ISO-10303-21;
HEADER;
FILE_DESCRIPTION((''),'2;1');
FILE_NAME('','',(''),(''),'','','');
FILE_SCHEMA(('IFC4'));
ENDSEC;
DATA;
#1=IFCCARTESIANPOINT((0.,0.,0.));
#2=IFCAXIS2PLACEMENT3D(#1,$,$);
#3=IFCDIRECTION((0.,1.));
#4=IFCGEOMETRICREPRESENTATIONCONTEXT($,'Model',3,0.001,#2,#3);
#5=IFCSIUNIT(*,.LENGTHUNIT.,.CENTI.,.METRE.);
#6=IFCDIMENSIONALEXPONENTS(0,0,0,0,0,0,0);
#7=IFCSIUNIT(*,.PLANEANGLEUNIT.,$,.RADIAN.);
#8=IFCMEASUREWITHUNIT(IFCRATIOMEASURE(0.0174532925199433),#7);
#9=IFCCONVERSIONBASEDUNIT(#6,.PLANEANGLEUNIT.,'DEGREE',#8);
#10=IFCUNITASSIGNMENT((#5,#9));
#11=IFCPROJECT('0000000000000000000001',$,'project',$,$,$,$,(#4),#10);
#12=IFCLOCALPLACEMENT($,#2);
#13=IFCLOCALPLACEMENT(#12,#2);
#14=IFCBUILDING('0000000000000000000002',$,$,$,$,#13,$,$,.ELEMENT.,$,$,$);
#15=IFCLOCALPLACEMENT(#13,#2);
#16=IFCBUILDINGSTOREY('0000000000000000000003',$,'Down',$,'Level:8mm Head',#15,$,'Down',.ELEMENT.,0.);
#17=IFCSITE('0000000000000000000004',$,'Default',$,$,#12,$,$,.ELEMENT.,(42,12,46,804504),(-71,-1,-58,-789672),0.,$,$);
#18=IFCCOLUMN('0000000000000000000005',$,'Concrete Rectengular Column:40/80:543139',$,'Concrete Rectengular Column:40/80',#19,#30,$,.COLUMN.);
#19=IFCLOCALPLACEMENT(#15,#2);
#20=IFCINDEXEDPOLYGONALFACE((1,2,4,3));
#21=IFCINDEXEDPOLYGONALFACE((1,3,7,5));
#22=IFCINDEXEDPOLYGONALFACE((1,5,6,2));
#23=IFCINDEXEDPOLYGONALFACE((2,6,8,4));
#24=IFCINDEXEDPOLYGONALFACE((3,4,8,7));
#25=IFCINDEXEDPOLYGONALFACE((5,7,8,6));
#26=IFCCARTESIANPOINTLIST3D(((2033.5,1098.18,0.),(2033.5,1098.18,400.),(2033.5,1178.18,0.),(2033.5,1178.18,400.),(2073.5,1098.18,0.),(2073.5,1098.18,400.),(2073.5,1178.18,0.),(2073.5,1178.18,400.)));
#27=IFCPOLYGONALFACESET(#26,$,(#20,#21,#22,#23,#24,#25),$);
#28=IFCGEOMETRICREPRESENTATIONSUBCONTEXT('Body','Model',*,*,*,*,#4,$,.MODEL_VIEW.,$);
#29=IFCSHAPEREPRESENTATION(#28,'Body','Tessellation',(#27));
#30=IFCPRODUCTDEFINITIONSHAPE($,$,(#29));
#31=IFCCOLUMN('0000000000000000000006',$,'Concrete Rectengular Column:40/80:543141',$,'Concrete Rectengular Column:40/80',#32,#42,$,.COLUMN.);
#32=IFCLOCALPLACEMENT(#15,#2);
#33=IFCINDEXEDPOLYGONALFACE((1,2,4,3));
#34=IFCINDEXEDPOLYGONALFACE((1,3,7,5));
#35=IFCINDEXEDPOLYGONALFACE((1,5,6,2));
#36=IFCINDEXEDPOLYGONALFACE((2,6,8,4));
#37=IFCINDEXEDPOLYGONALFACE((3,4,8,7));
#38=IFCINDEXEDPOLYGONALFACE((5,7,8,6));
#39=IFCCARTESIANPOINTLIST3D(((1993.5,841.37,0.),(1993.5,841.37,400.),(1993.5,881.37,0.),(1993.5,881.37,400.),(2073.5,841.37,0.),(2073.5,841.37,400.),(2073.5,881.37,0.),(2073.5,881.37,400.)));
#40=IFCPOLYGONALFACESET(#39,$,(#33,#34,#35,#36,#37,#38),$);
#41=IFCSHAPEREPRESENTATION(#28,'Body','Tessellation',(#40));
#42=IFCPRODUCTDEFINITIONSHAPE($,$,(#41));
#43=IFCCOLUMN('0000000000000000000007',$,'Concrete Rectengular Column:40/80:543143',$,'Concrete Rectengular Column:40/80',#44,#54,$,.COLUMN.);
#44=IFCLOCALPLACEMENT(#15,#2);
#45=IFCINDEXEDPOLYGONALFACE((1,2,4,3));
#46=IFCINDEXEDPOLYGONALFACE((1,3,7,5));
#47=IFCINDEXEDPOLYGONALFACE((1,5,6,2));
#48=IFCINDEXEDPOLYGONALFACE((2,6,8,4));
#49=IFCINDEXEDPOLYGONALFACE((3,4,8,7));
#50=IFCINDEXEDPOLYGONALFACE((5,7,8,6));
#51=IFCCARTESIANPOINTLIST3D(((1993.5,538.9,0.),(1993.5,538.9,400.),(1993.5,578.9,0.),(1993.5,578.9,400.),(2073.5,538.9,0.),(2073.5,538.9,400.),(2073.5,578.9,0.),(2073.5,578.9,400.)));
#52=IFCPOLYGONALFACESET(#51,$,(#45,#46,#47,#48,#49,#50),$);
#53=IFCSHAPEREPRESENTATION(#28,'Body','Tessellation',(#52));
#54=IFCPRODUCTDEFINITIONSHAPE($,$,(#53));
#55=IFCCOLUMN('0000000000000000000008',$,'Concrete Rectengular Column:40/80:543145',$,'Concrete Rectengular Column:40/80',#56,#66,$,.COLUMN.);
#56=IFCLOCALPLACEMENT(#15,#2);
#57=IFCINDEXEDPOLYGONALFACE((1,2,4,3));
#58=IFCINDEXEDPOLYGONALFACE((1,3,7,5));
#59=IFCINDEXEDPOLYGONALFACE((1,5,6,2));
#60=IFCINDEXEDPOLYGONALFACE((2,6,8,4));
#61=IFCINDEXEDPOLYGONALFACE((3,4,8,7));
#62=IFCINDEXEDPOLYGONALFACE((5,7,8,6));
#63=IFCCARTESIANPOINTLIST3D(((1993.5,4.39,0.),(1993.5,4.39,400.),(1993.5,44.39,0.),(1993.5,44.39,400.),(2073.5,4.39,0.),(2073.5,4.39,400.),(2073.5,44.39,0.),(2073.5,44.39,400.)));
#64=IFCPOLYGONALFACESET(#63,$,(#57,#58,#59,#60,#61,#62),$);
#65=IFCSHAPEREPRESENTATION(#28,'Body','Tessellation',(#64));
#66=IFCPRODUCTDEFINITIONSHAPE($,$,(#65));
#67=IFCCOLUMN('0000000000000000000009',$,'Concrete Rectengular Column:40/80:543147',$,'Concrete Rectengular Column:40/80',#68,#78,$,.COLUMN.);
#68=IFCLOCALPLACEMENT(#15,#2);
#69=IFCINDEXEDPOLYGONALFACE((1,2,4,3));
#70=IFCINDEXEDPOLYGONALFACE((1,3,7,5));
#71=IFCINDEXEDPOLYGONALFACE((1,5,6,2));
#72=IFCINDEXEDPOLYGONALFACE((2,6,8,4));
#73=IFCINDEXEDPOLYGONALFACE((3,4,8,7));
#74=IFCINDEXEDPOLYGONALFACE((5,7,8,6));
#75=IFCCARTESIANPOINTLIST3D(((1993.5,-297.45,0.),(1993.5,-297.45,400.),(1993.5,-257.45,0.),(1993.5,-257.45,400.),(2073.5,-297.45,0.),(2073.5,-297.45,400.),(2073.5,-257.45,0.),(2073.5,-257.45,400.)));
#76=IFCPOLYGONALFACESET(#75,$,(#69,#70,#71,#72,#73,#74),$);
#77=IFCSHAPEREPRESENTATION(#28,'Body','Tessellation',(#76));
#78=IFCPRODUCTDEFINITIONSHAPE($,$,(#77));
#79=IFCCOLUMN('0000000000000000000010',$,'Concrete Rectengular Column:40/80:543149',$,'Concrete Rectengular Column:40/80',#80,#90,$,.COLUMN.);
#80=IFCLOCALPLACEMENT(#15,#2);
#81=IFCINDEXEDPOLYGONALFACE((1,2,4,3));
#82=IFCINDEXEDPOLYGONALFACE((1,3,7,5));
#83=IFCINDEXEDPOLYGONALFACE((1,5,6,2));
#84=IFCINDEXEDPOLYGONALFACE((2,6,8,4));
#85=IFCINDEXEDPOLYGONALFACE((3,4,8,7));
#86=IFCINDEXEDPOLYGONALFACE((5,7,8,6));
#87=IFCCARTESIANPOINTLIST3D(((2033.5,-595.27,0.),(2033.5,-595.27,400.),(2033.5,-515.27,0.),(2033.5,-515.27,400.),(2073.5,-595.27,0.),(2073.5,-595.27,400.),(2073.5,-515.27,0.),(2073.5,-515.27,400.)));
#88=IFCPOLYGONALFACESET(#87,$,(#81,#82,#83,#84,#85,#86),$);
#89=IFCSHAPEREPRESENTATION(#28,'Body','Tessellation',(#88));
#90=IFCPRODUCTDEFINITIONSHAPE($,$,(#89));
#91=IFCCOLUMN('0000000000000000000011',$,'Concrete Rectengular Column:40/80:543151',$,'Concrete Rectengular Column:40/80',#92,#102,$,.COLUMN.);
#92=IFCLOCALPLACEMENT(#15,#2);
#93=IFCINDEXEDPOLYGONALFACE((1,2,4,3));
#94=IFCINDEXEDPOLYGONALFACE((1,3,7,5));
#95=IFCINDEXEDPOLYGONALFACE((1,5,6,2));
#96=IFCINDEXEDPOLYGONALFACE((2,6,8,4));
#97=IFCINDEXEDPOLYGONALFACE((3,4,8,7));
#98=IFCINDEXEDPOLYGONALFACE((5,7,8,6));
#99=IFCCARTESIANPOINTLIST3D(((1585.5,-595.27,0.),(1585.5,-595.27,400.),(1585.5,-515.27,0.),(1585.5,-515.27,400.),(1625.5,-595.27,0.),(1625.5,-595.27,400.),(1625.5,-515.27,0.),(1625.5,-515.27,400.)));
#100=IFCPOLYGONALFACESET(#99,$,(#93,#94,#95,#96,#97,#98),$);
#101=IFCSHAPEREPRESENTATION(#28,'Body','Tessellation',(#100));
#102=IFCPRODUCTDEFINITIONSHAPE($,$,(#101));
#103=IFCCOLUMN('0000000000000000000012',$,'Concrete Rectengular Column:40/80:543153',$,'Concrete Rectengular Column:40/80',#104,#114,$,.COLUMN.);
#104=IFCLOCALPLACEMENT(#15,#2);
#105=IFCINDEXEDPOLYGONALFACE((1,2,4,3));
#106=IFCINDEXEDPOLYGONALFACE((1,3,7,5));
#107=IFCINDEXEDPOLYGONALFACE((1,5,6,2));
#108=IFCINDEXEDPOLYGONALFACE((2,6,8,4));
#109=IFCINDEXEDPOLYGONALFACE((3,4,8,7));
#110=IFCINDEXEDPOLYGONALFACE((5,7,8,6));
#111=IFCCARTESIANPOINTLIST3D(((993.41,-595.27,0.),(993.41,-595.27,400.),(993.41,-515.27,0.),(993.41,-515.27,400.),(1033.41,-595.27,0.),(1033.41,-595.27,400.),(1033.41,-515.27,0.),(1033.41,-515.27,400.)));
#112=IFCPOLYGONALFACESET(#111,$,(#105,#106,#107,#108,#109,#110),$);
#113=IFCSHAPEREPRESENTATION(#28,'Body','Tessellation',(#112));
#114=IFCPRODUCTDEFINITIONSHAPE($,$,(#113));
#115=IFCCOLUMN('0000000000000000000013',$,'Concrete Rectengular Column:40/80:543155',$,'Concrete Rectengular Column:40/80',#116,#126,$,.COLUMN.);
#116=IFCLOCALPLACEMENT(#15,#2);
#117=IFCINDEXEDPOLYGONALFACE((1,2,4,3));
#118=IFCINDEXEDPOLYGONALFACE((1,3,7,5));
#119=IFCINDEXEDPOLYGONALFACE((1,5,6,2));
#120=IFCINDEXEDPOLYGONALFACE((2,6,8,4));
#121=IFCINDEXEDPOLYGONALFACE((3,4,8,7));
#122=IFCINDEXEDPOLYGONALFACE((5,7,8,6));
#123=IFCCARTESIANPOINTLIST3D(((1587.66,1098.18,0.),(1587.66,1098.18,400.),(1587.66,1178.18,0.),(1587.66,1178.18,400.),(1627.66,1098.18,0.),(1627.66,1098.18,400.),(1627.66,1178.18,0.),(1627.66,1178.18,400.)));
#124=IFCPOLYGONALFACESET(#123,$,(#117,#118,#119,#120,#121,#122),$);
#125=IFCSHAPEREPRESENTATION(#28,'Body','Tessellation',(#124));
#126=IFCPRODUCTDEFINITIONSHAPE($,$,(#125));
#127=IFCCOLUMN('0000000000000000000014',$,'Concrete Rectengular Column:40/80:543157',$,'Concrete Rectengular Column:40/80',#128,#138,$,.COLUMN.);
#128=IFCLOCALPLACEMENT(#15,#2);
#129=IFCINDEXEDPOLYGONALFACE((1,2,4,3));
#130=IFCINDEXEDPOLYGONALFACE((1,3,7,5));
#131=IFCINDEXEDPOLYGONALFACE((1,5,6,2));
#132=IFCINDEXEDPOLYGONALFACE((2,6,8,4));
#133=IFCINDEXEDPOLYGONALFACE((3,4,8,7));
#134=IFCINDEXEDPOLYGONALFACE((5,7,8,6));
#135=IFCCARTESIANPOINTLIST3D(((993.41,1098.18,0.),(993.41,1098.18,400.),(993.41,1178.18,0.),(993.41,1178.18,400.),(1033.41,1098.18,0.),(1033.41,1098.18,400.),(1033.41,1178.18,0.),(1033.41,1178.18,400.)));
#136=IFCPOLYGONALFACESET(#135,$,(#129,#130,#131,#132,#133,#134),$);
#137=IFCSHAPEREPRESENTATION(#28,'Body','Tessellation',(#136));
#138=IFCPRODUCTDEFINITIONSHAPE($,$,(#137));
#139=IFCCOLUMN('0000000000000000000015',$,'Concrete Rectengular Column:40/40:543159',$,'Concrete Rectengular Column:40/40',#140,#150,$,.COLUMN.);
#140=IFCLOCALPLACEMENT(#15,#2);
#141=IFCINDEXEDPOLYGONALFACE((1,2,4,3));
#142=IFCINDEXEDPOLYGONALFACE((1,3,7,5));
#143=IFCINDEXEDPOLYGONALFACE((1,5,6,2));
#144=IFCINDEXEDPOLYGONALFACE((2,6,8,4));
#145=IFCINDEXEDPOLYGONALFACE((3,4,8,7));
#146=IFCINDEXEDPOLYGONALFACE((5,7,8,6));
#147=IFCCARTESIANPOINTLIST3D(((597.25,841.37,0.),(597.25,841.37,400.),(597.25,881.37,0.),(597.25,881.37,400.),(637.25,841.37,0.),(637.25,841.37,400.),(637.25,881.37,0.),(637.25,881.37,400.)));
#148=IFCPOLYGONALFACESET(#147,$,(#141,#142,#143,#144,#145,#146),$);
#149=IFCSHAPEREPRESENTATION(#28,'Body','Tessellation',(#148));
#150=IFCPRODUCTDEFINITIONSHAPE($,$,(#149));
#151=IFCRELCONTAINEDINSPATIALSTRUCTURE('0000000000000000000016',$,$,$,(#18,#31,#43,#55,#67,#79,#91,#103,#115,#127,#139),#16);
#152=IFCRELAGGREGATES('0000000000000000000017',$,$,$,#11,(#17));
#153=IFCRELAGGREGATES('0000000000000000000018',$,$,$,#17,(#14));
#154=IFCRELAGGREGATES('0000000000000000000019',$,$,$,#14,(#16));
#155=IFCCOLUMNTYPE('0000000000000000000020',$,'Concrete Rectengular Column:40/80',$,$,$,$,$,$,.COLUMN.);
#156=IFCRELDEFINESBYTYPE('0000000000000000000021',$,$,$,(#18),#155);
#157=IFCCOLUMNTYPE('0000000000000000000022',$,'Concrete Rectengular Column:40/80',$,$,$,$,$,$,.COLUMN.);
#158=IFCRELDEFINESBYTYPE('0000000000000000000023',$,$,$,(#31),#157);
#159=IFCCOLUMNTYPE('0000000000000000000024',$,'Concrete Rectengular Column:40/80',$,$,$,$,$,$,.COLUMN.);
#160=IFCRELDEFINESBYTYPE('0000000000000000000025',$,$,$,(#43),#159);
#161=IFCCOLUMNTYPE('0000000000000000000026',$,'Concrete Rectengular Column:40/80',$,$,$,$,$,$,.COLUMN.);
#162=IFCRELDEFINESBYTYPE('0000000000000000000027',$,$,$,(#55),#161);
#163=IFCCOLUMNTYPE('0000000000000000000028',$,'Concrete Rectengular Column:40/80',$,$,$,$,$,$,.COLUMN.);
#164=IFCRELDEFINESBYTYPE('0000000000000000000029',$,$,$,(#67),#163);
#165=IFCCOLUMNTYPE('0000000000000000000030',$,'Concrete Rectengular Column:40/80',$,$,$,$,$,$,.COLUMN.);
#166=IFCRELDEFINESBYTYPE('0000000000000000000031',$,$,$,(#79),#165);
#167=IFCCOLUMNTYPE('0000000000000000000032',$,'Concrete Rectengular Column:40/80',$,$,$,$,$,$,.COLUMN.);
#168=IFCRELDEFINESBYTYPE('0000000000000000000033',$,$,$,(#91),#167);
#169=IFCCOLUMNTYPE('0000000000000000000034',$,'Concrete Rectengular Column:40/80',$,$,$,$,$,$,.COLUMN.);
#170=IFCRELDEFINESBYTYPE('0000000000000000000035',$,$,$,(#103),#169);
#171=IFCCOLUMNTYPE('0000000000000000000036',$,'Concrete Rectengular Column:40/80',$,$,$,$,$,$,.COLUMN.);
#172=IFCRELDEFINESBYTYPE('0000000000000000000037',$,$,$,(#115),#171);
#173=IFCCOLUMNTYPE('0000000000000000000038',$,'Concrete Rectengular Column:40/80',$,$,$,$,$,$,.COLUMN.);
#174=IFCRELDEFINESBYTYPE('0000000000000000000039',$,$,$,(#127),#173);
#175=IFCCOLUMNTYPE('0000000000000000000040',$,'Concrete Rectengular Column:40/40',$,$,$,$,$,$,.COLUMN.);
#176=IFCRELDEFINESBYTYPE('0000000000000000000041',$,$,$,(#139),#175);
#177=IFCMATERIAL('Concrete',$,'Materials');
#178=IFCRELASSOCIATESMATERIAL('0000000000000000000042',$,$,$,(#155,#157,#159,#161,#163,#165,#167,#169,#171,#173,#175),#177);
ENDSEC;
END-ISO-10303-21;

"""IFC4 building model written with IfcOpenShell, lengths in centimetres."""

from ifc_helpers import new_model, entity, si_unit, converted_unit, direction, frame, origin, place, context, subcontext, project, spatial, indexed_curve, outline, extrude, source, transform, mapped, material, type_object, type_shapes, element, save


model = new_model("IFC4")

# Units and contexts
model_context = context("Model", 3, precision=0.001, world=origin(), true_north=direction((0.0, 1.0)))
body_context = subcontext(model_context, "Body", "Model", "MODEL_VIEW")
ifc_project = project(units=[si_unit("LENGTHUNIT", "METRE", prefix="CENTI"), converted_unit("PLANEANGLEUNIT", "DEGREE", entity("IfcRatioMeasure", 0.0174532925199433), si_unit("PLANEANGLEUNIT", "RADIAN"), dimensions=[0, 0, 0, 0, 0, 0, 0])], contexts=[model_context])

# Site, building, storey
site_placement = place(None, origin())
site = spatial("IfcSite", under=ifc_project, at=site_placement, Name="Default", CompositionType="ELEMENT", RefLatitude=(42, 12, 46, 804504), RefLongitude=(-71, -1, -58, -789672), RefElevation=0.0)
building_placement = place(site_placement, origin())
building = spatial("IfcBuilding", under=site, at=building_placement, CompositionType="ELEMENT")
storey_placement = place(building_placement, origin())
storey = spatial("IfcBuildingStorey", under=building, at=storey_placement, Name="Down", ObjectType="Level:8mm Head", LongName="Down", CompositionType="ELEMENT", Elevation=0.0)

# Columns
ifc_material = material(Name="Concrete", Category="Materials")
column_type_1 = type_object("IfcColumnType", Name="Concrete Rectengular Column:40/80", PredefinedType="COLUMN", material=ifc_material)
shared_shape_1 = source(origin(), body_context, "Body", "SweptSolid", [
    extrude(outline(indexed_curve([(-40.0, -20.0), (40.0, -20.0), (40.0, 20.0), (-40.0, 20.0), (-40.0, -20.0)], self_intersect=False)), frame((2053.5, 1138.18, 0.0), z_axis=(0.0, 0.0, 1.0), x_axis=(0.0, -1.0, 0.0)), (0.0, 0.0, 1.0), 400.0),
])
type_shapes(column_type_1, [shared_shape_1])
column_1_placement = place(storey_placement, origin())
element("IfcColumn", 1, at=column_1_placement, inside=storey, type_object=column_type_1, Name="Concrete Rectengular Column:40/80:543139", ObjectType="Concrete Rectengular Column:40/80", PredefinedType="COLUMN", context=body_context, shape_type="MappedRepresentation", body=[
    mapped(shared_shape_1, transform((0.0, 0.0, 0.0), scale=1.0)),
])
column_type_2 = type_object("IfcColumnType", Name="Concrete Rectengular Column:40/80", PredefinedType="COLUMN", material=ifc_material)
shared_shape_2 = source(origin(), body_context, "Body", "SweptSolid", [
    extrude(outline(indexed_curve([(-20.0, -40.0), (20.0, -40.0), (20.0, 40.0), (-20.0, 40.0), (-20.0, -40.0)], self_intersect=False)), frame((2033.5, 861.37, 0.0), z_axis=(0.0, 0.0, 1.0), x_axis=(0.0, -1.0, 0.0)), (0.0, 0.0, 1.0), 400.0),
])
type_shapes(column_type_2, [shared_shape_2])
column_2_placement = place(storey_placement, origin())
element("IfcColumn", 2, at=column_2_placement, inside=storey, type_object=column_type_2, Name="Concrete Rectengular Column:40/80:543141", ObjectType="Concrete Rectengular Column:40/80", PredefinedType="COLUMN", context=body_context, shape_type="MappedRepresentation", body=[
    mapped(shared_shape_2, transform((0.0, 0.0, 0.0), scale=1.0)),
])
column_type_3 = type_object("IfcColumnType", Name="Concrete Rectengular Column:40/80", PredefinedType="COLUMN", material=ifc_material)
shared_shape_3 = source(origin(), body_context, "Body", "SweptSolid", [
    extrude(outline(indexed_curve([(-20.0, -40.0), (20.0, -40.0), (20.0, 40.0), (-20.0, 40.0), (-20.0, -40.0)], self_intersect=False)), frame((2033.5, 558.9, 0.0), z_axis=(0.0, 0.0, 1.0), x_axis=(0.0, -1.0, 0.0)), (0.0, 0.0, 1.0), 400.0),
])
type_shapes(column_type_3, [shared_shape_3])
column_3_placement = place(storey_placement, origin())
element("IfcColumn", 3, at=column_3_placement, inside=storey, type_object=column_type_3, Name="Concrete Rectengular Column:40/80:543143", ObjectType="Concrete Rectengular Column:40/80", PredefinedType="COLUMN", context=body_context, shape_type="MappedRepresentation", body=[
    mapped(shared_shape_3, transform((0.0, 0.0, 0.0), scale=1.0)),
])
column_type_4 = type_object("IfcColumnType", Name="Concrete Rectengular Column:40/80", PredefinedType="COLUMN", material=ifc_material)
shared_shape_4 = source(origin(), body_context, "Body", "SweptSolid", [
    extrude(outline(indexed_curve([(-20.0, -40.0), (20.0, -40.0), (20.0, 40.0), (-20.0, 40.0), (-20.0, -40.0)], self_intersect=False)), frame((2033.5, 24.39, 0.0), z_axis=(0.0, 0.0, 1.0), x_axis=(0.0, -1.0, 0.0)), (0.0, 0.0, 1.0), 400.0),
])
type_shapes(column_type_4, [shared_shape_4])
column_4_placement = place(storey_placement, origin())
element("IfcColumn", 4, at=column_4_placement, inside=storey, type_object=column_type_4, Name="Concrete Rectengular Column:40/80:543145", ObjectType="Concrete Rectengular Column:40/80", PredefinedType="COLUMN", context=body_context, shape_type="MappedRepresentation", body=[
    mapped(shared_shape_4, transform((0.0, 0.0, 0.0), scale=1.0)),
])
column_type_5 = type_object("IfcColumnType", Name="Concrete Rectengular Column:40/80", PredefinedType="COLUMN", material=ifc_material)
shared_shape_5 = source(origin(), body_context, "Body", "SweptSolid", [
    extrude(outline(indexed_curve([(-20.0, -40.0), (20.0, -40.0), (20.0, 40.0), (-20.0, 40.0), (-20.0, -40.0)], self_intersect=False)), frame((2033.5, -277.45, 0.0), z_axis=(0.0, 0.0, 1.0), x_axis=(0.0, -1.0, 0.0)), (0.0, 0.0, 1.0), 400.0),
])
type_shapes(column_type_5, [shared_shape_5])
column_5_placement = place(storey_placement, origin())
element("IfcColumn", 5, at=column_5_placement, inside=storey, type_object=column_type_5, Name="Concrete Rectengular Column:40/80:543147", ObjectType="Concrete Rectengular Column:40/80", PredefinedType="COLUMN", context=body_context, shape_type="MappedRepresentation", body=[
    mapped(shared_shape_5, transform((0.0, 0.0, 0.0), scale=1.0)),
])
column_type_6 = type_object("IfcColumnType", Name="Concrete Rectengular Column:40/80", PredefinedType="COLUMN", material=ifc_material)
shared_shape_6 = source(origin(), body_context, "Body", "SweptSolid", [
    extrude(outline(indexed_curve([(-40.0, -20.0), (40.0, -20.0), (40.0, 20.0), (-40.0, 20.0), (-40.0, -20.0)], self_intersect=False)), frame((2053.5, -555.27, 0.0), z_axis=(0.0, 0.0, 1.0), x_axis=(0.0, -1.0, 0.0)), (0.0, 0.0, 1.0), 400.0),
])
type_shapes(column_type_6, [shared_shape_6])
column_6_placement = place(storey_placement, origin())
element("IfcColumn", 6, at=column_6_placement, inside=storey, type_object=column_type_6, Name="Concrete Rectengular Column:40/80:543149", ObjectType="Concrete Rectengular Column:40/80", PredefinedType="COLUMN", context=body_context, shape_type="MappedRepresentation", body=[
    mapped(shared_shape_6, transform((0.0, 0.0, 0.0), scale=1.0)),
])
column_type_7 = type_object("IfcColumnType", Name="Concrete Rectengular Column:40/80", PredefinedType="COLUMN", material=ifc_material)
shared_shape_7 = source(origin(), body_context, "Body", "SweptSolid", [
    extrude(outline(indexed_curve([(-40.0, -20.0), (40.0, -20.0), (40.0, 20.0), (-40.0, 20.0), (-40.0, -20.0)], self_intersect=False)), frame((1605.5, -555.27, 0.0), z_axis=(0.0, 0.0, 1.0), x_axis=(0.0, -1.0, 0.0)), (0.0, 0.0, 1.0), 400.0),
])
type_shapes(column_type_7, [shared_shape_7])
column_7_placement = place(storey_placement, origin())
element("IfcColumn", 7, at=column_7_placement, inside=storey, type_object=column_type_7, Name="Concrete Rectengular Column:40/80:543151", ObjectType="Concrete Rectengular Column:40/80", PredefinedType="COLUMN", context=body_context, shape_type="MappedRepresentation", body=[
    mapped(shared_shape_7, transform((0.0, 0.0, 0.0), scale=1.0)),
])
column_type_8 = type_object("IfcColumnType", Name="Concrete Rectengular Column:40/80", PredefinedType="COLUMN", material=ifc_material)
shared_shape_8 = source(origin(), body_context, "Body", "SweptSolid", [
    extrude(outline(indexed_curve([(-40.0, -20.0), (40.0, -20.0), (40.0, 20.0), (-40.0, 20.0), (-40.0, -20.0)], self_intersect=False)), frame((1013.41, -555.27, 0.0), z_axis=(0.0, 0.0, 1.0), x_axis=(0.0, -1.0, 0.0)), (0.0, 0.0, 1.0), 400.0),
])
type_shapes(column_type_8, [shared_shape_8])
column_8_placement = place(storey_placement, origin())
element("IfcColumn", 8, at=column_8_placement, inside=storey, type_object=column_type_8, Name="Concrete Rectengular Column:40/80:543153", ObjectType="Concrete Rectengular Column:40/80", PredefinedType="COLUMN", context=body_context, shape_type="MappedRepresentation", body=[
    mapped(shared_shape_8, transform((0.0, 0.0, 0.0), scale=1.0)),
])
column_type_9 = type_object("IfcColumnType", Name="Concrete Rectengular Column:40/80", PredefinedType="COLUMN", material=ifc_material)
shared_shape_9 = source(origin(), body_context, "Body", "SweptSolid", [
    extrude(outline(indexed_curve([(-40.0, -20.0), (40.0, -20.0), (40.0, 20.0), (-40.0, 20.0), (-40.0, -20.0)], self_intersect=False)), frame((1607.66, 1138.18, 0.0), z_axis=(0.0, 0.0, 1.0), x_axis=(0.0, -1.0, 0.0)), (0.0, 0.0, 1.0), 400.0),
])
type_shapes(column_type_9, [shared_shape_9])
column_9_placement = place(storey_placement, origin())
element("IfcColumn", 9, at=column_9_placement, inside=storey, type_object=column_type_9, Name="Concrete Rectengular Column:40/80:543155", ObjectType="Concrete Rectengular Column:40/80", PredefinedType="COLUMN", context=body_context, shape_type="MappedRepresentation", body=[
    mapped(shared_shape_9, transform((0.0, 0.0, 0.0), scale=1.0)),
])
column_type_10 = type_object("IfcColumnType", Name="Concrete Rectengular Column:40/80", PredefinedType="COLUMN", material=ifc_material)
shared_shape_10 = source(origin(), body_context, "Body", "SweptSolid", [
    extrude(outline(indexed_curve([(-40.0, -20.0), (40.0, -20.0), (40.0, 20.0), (-40.0, 20.0), (-40.0, -20.0)], self_intersect=False)), frame((1013.41, 1138.18, 0.0), z_axis=(0.0, 0.0, 1.0), x_axis=(0.0, -1.0, 0.0)), (0.0, 0.0, 1.0), 400.0),
])
type_shapes(column_type_10, [shared_shape_10])
column_10_placement = place(storey_placement, origin())
element("IfcColumn", 10, at=column_10_placement, inside=storey, type_object=column_type_10, Name="Concrete Rectengular Column:40/80:543157", ObjectType="Concrete Rectengular Column:40/80", PredefinedType="COLUMN", context=body_context, shape_type="MappedRepresentation", body=[
    mapped(shared_shape_10, transform((0.0, 0.0, 0.0), scale=1.0)),
])
column_type_11 = type_object("IfcColumnType", Name="Concrete Rectengular Column:40/40", PredefinedType="COLUMN", material=ifc_material)
shared_shape_11 = source(origin(), body_context, "Body", "SweptSolid", [
    extrude(outline(indexed_curve([(-20.0, -20.0), (20.0, -20.0), (20.0, 20.0), (-20.0, 20.0), (-20.0, -20.0)], self_intersect=False)), frame((617.25, 861.37, 0.0), z_axis=(0.0, 0.0, 1.0), x_axis=(0.0, -1.0, 0.0)), (0.0, 0.0, 1.0), 400.0),
])
type_shapes(column_type_11, [shared_shape_11])
column_11_placement = place(storey_placement, origin())
element("IfcColumn", 11, at=column_11_placement, inside=storey, type_object=column_type_11, Name="Concrete Rectengular Column:40/40:543159", ObjectType="Concrete Rectengular Column:40/40", PredefinedType="COLUMN", context=body_context, shape_type="MappedRepresentation", body=[
    mapped(shared_shape_11, transform((0.0, 0.0, 0.0), scale=1.0)),
])

save(model, "model.ifc")
